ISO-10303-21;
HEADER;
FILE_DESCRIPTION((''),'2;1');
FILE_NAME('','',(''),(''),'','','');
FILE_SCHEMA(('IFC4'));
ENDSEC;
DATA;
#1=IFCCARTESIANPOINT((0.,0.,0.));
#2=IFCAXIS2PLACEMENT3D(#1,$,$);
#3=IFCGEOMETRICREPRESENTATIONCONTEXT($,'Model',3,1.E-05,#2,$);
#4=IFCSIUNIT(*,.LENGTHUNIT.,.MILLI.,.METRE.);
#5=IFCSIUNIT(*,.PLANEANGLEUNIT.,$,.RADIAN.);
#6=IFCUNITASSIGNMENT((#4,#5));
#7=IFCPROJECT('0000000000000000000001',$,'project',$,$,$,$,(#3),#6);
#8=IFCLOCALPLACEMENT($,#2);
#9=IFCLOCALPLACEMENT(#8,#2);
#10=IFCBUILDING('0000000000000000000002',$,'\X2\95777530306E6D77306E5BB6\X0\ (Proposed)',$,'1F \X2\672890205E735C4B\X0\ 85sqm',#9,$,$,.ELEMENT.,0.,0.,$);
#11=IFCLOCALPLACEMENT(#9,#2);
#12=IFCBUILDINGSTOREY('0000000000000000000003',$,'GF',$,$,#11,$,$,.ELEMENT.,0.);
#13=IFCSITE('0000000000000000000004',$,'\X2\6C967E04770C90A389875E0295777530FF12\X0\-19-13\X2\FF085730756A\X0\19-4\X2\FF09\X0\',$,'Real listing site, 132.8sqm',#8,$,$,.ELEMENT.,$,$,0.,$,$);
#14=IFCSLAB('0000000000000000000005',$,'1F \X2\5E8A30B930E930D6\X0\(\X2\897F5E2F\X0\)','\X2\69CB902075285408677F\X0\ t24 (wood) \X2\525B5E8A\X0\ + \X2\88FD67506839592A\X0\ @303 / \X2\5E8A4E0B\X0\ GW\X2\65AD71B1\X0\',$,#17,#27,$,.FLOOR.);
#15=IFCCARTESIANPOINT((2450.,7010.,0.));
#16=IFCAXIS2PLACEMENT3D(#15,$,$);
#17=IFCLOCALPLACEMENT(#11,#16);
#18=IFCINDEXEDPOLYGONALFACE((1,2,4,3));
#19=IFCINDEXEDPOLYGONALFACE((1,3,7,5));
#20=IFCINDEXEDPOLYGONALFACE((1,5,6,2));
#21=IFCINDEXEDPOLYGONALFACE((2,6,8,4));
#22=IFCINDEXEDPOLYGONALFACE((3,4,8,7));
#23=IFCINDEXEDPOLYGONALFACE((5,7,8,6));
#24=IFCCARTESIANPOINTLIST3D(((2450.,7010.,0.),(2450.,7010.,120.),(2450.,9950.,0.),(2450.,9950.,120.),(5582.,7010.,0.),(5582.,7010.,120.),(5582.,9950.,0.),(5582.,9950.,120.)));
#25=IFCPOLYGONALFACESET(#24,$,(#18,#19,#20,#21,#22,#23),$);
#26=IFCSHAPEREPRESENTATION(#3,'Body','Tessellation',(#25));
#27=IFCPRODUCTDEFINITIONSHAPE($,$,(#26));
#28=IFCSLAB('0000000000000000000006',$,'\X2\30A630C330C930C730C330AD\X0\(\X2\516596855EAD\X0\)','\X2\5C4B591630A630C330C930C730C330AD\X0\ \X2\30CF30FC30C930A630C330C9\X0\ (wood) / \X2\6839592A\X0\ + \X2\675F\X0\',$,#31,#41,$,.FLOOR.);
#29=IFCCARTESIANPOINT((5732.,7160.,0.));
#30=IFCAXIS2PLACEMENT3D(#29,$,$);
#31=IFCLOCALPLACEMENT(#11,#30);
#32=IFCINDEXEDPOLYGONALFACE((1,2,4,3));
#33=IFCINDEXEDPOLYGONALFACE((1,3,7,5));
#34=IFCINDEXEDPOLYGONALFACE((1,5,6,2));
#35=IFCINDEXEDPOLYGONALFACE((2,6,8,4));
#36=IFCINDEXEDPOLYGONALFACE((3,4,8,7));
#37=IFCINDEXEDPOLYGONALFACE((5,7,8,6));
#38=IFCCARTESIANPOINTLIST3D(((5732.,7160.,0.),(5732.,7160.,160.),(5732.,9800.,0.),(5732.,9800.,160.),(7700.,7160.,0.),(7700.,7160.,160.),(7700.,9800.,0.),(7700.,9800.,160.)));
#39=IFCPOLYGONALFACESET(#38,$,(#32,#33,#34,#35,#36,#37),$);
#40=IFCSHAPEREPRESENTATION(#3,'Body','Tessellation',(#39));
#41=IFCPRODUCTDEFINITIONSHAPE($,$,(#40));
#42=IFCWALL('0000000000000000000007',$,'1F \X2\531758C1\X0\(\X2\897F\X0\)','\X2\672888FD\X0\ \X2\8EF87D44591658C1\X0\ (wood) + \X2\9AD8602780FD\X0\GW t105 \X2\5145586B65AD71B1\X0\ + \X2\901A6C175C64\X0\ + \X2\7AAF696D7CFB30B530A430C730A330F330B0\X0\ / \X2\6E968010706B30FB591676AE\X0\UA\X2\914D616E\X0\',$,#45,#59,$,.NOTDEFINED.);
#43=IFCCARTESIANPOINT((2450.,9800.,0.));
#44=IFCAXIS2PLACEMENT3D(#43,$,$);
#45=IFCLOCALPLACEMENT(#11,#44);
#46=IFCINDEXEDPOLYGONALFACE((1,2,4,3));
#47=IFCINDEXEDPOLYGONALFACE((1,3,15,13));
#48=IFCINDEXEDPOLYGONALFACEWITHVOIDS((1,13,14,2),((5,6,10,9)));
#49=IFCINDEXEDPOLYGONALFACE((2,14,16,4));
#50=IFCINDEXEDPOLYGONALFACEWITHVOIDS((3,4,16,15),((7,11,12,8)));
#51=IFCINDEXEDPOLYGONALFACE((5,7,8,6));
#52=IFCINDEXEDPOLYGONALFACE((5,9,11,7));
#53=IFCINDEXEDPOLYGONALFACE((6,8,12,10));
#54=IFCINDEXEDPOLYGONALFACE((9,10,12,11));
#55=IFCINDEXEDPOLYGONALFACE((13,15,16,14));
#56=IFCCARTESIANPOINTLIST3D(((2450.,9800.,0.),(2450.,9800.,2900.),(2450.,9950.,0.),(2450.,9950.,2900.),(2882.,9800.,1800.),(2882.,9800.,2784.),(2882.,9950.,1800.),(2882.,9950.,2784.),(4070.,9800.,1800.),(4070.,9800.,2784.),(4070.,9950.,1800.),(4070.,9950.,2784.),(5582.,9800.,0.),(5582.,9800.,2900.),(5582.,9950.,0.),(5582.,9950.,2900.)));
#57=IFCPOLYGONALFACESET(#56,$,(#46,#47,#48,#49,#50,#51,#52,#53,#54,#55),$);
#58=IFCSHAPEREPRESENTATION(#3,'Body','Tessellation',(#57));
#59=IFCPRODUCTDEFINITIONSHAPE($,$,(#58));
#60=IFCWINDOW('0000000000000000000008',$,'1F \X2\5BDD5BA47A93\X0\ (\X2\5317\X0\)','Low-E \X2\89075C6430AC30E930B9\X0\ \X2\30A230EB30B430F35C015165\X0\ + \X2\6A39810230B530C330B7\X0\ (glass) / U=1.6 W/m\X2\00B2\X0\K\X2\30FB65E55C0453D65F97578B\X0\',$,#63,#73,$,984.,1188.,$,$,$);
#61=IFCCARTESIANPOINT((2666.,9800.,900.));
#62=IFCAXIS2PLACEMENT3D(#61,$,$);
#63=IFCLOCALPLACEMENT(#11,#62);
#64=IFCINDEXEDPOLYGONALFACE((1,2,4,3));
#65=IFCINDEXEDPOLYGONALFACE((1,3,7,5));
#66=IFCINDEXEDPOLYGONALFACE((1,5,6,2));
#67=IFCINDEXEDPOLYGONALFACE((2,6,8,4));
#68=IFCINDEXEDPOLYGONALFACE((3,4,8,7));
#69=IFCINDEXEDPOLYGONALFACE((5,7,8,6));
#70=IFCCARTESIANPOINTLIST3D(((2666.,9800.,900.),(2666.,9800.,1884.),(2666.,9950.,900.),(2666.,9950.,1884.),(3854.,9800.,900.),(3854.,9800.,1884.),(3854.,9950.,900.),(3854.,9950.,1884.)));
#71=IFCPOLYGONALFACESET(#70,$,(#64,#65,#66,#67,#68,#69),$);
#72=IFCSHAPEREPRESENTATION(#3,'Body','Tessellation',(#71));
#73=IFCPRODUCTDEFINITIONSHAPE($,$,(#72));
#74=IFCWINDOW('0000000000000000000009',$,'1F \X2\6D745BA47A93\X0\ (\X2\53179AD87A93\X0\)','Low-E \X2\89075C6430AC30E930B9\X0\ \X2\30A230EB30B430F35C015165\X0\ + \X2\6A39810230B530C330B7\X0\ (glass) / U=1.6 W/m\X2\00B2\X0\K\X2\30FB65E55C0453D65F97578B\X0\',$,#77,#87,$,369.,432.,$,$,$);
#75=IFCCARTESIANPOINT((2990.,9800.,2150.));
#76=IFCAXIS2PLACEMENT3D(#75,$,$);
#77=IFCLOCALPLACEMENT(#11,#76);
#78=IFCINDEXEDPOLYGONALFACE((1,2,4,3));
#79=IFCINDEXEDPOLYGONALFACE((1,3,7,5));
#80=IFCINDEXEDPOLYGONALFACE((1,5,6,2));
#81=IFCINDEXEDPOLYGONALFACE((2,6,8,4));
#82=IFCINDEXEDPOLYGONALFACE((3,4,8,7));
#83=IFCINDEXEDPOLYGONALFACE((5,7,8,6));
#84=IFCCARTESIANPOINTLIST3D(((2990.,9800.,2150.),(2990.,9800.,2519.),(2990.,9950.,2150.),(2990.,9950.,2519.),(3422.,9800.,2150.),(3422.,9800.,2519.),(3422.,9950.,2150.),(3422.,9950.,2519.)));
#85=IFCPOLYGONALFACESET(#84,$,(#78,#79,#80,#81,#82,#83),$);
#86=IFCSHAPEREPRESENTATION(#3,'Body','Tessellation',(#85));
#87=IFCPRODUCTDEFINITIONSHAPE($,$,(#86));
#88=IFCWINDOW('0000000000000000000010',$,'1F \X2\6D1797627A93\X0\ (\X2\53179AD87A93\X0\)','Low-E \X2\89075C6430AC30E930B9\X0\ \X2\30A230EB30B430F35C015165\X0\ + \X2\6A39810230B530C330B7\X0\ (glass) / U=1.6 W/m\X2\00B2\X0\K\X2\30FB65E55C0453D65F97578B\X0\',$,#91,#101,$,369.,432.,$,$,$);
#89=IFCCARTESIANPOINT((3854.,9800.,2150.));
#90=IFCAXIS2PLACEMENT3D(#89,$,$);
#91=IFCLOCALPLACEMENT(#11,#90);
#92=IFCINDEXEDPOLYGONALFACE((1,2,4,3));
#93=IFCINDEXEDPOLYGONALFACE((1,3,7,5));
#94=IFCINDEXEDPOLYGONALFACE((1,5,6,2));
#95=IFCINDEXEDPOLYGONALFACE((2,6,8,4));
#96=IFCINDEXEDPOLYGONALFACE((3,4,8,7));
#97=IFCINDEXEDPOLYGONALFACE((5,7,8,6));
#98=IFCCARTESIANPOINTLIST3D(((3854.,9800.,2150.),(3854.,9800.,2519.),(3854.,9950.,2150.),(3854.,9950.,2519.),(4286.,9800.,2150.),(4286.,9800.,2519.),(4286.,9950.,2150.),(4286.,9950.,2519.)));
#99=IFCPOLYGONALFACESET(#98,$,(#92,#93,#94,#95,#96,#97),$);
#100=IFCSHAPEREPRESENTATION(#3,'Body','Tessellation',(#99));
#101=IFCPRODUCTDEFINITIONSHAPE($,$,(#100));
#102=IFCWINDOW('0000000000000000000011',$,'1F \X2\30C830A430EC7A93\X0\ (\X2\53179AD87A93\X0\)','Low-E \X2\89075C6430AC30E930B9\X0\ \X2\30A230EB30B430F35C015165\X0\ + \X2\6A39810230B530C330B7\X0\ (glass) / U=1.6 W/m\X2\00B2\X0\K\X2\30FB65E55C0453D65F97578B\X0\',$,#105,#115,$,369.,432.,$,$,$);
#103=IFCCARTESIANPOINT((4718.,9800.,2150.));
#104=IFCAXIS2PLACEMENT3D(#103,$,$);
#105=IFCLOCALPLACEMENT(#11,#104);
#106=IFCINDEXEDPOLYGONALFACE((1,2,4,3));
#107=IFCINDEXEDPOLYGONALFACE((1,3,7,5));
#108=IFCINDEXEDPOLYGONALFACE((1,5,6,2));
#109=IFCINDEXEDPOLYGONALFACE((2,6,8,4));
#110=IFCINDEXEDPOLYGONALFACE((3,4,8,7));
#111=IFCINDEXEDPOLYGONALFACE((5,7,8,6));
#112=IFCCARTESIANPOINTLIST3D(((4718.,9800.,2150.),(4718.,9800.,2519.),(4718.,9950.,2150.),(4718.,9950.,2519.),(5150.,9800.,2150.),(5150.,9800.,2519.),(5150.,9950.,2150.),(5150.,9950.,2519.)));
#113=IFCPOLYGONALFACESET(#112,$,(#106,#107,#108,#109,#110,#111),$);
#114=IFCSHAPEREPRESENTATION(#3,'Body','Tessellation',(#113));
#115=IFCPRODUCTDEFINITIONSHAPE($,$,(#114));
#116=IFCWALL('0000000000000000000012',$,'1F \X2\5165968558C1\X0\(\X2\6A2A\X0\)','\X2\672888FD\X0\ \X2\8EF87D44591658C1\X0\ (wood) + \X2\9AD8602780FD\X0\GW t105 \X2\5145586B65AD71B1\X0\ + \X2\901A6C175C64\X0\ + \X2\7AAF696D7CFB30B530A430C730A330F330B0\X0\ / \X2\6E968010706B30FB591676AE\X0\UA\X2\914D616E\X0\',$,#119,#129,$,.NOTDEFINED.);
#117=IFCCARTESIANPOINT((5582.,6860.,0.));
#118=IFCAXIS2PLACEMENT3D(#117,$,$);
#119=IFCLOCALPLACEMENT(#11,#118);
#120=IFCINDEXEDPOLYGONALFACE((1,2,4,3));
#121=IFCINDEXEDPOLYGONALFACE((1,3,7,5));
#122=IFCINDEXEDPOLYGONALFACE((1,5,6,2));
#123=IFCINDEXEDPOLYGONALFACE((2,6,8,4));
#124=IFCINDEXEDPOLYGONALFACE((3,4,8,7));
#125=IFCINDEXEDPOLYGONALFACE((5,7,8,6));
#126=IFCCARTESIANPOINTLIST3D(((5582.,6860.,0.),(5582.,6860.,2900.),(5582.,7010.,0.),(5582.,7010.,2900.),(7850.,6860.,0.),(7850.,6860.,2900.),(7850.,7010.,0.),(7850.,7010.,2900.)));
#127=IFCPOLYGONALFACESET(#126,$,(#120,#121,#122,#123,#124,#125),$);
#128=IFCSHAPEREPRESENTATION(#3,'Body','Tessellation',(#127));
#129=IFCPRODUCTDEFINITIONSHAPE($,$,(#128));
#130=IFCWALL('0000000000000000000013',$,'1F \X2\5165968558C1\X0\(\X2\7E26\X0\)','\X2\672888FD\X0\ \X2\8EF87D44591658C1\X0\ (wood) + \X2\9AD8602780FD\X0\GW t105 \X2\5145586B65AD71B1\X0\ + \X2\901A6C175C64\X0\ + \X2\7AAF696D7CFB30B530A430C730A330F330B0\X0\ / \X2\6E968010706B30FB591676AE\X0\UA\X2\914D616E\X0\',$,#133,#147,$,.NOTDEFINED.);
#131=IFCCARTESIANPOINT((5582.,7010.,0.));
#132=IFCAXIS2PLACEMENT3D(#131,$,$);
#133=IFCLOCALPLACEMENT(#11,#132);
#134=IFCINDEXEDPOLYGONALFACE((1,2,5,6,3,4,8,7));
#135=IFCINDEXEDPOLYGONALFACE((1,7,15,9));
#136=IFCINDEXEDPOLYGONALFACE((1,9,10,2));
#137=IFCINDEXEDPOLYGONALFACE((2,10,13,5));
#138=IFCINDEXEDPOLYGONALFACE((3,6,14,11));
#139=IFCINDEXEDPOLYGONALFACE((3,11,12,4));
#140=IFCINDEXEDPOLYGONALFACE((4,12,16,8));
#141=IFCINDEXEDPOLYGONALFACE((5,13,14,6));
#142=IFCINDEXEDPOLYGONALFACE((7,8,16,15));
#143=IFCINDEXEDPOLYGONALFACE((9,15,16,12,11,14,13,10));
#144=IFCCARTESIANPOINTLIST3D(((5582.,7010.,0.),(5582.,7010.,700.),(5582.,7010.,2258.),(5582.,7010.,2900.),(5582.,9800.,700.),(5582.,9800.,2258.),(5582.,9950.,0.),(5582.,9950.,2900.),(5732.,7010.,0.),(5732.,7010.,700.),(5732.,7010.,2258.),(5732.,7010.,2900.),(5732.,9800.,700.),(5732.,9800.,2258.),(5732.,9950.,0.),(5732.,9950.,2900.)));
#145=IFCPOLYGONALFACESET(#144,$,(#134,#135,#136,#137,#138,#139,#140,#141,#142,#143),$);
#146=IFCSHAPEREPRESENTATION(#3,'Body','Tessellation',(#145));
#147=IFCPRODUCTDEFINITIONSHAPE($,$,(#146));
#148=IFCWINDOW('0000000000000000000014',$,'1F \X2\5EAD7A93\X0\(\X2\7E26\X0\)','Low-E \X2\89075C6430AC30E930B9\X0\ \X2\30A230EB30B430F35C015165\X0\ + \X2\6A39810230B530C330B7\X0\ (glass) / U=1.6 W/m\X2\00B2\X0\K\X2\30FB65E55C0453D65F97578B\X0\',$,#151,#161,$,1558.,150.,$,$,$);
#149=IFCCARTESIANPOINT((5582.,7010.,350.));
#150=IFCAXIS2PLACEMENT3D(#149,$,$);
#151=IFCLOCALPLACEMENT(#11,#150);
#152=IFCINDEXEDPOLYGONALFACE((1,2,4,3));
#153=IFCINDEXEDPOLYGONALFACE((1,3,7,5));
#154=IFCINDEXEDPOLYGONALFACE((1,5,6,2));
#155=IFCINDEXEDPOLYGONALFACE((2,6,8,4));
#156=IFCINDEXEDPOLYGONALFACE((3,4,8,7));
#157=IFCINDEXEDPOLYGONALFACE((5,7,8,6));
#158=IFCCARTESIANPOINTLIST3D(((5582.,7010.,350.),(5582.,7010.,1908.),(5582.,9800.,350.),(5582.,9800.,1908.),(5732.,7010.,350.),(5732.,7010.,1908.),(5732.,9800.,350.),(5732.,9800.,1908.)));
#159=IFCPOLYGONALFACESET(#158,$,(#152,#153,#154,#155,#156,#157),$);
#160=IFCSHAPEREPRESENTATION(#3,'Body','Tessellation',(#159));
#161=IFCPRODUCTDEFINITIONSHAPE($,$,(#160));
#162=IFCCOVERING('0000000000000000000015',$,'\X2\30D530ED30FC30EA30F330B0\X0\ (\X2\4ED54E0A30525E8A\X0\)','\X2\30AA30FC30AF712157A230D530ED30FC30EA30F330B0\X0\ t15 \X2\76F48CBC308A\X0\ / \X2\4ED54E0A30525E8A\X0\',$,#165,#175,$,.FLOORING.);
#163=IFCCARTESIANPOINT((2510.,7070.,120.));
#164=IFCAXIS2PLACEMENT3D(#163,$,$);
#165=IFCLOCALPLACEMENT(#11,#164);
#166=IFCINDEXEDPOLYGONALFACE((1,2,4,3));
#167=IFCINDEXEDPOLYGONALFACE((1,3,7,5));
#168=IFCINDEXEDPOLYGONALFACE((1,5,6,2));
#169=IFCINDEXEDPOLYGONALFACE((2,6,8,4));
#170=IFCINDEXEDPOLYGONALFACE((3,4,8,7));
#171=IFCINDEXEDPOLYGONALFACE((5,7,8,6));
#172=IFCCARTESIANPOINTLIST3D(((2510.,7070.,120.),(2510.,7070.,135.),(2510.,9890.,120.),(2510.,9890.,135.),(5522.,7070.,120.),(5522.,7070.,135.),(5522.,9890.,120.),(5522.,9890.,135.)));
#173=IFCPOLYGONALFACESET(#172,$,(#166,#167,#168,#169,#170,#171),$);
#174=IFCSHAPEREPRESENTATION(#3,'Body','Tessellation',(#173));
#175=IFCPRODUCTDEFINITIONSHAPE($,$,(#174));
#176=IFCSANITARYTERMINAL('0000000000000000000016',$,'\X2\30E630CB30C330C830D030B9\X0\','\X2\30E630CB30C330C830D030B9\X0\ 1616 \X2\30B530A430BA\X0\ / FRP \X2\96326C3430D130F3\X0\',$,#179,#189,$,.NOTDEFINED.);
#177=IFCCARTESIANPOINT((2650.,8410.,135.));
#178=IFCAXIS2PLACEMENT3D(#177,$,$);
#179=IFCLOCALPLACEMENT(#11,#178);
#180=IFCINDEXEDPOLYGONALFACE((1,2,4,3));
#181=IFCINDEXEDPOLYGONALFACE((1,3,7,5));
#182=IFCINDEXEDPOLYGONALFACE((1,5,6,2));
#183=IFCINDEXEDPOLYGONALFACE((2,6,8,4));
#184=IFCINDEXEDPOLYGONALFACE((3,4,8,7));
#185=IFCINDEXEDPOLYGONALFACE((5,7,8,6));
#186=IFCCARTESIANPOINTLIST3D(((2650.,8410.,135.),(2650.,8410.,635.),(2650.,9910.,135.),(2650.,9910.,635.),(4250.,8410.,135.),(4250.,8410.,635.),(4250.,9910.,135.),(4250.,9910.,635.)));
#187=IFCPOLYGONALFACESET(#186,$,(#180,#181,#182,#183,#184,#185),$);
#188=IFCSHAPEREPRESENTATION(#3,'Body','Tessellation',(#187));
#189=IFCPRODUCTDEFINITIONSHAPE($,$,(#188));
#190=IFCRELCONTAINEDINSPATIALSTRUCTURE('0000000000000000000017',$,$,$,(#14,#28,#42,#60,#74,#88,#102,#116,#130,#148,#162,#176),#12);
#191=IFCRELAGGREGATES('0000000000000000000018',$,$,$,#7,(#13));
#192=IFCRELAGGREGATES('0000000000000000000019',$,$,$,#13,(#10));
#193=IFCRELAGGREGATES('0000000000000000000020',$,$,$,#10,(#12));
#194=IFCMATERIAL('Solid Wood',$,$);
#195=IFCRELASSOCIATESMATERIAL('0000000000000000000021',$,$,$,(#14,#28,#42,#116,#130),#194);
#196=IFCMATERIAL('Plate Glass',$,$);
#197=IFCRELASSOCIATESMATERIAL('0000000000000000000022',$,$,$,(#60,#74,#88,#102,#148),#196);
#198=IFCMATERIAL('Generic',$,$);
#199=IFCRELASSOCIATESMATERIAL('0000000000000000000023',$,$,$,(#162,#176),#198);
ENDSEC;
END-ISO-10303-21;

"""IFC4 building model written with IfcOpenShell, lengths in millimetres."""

from ifc_helpers import new_model, si_unit, frame, frame_2d, origin, place, context, project, spatial, rectangle, extrude, material, element, fill, save


model = new_model("IFC4")

# Units and contexts
model_context = context("Model", 3, precision=1e-05, world=origin())
ifc_project = project(units=[si_unit("LENGTHUNIT", "METRE", prefix="MILLI"), si_unit("PLANEANGLEUNIT", "RADIAN")], contexts=[model_context])

# Site, building, storey
site_placement = place(None, origin())
site = spatial("IfcSite", under=ifc_project, at=site_placement, Name="沖縄県那覇市長田２-19-13（地番19-4）", ObjectType="Real listing site, 132.8sqm", CompositionType="ELEMENT", RefElevation=0.0)
building_placement = place(site_placement, origin())
building = spatial("IfcBuilding", under=site, at=building_placement, Name="長田の海の家 (Proposed)", ObjectType="1F 木造平屋 85sqm", CompositionType="ELEMENT", ElevationOfRefHeight=0.0, ElevationOfTerrain=0.0)
storey_placement = place(building_placement, origin())
storey = spatial("IfcBuildingStorey", under=building, at=storey_placement, Name="GF", CompositionType="ELEMENT", Elevation=0.0)

# Slabs
ifc_material_1 = material(Name="Solid Wood")
slab_1_placement = place(storey_placement, frame((2450.0, 7010.0, 0.0)))
element("IfcSlab", 1, at=slab_1_placement, inside=storey, material=ifc_material_1, Name="1F 床スラブ(西帯)", Description="構造用合板 t24 (wood) 剛床 + 製材根太 @303 / 床下 GW断熱", PredefinedType="FLOOR", context=model_context, shape_type="SweptSolid", body=[
    extrude(rectangle(XDim=3132.0, YDim=2940.0, at=frame_2d((1566.0, 1470.0))), frame((2450.0, 7010.0, 0.0)), (0.0, 0.0, 1.0), 120.0),
])
slab_2_placement = place(storey_placement, frame((5732.0, 7160.0, 0.0)))
element("IfcSlab", 2, at=slab_2_placement, inside=storey, material=ifc_material_1, Name="ウッドデッキ(入隅庭)", Description="屋外ウッドデッキ ハードウッド (wood) / 根太 + 束", PredefinedType="FLOOR", context=model_context, shape_type="SweptSolid", body=[
    extrude(rectangle(XDim=1968.0, YDim=2640.0, at=frame_2d((984.0, 1320.0))), frame((5732.0, 7160.0, 0.0)), (0.0, 0.0, 1.0), 160.0),
])

# Wall, openings, windows
wall_1_placement = place(storey_placement, frame((2450.0, 9800.0, 0.0)))
wall_1 = element("IfcWall", 3, at=wall_1_placement, inside=storey, material=ifc_material_1, Name="1F 北壁(西)", Description="木製 軸組外壁 (wood) + 高性能GW t105 充填断熱 + 通気層 + 窯業系サイディング / 準耐火・外皮UA配慮", PredefinedType="NOTDEFINED", context=model_context, shape_type="SweptSolid", body=[
    extrude(rectangle(XDim=3132.0, YDim=150.0, at=frame_2d((1566.0, 75.0))), frame((2450.0, 9800.0, 0.0)), (0.0, 0.0, 1.0), 2900.0),
])
opening_1_placement = place(storey_placement, frame((2666.0, 9800.0, 900.0)))
opening_1 = element("IfcOpeningElement", 4, at=opening_1_placement, cuts=wall_1, PredefinedType="NOTDEFINED", context=model_context, shape_type="SweptSolid", body=[
    extrude(rectangle(XDim=1188.0, YDim=150.0, at=frame_2d((594.0, 75.0))), frame((2666.0, 9800.0, 900.0)), (0.0, 0.0, 1.0), 984.0),
])
opening_2_placement = place(storey_placement, frame((2990.0, 9800.0, 2150.0)))
opening_2 = element("IfcOpeningElement", 5, at=opening_2_placement, cuts=wall_1, PredefinedType="NOTDEFINED", context=model_context, shape_type="SweptSolid", body=[
    extrude(rectangle(XDim=432.0, YDim=150.0, at=frame_2d((216.0, 75.0))), frame((2990.0, 9800.0, 2150.0)), (0.0, 0.0, 1.0), 369.0),
])
opening_3_placement = place(storey_placement, frame((3854.0, 9800.0, 2150.0)))
opening_3 = element("IfcOpeningElement", 6, at=opening_3_placement, cuts=wall_1, PredefinedType="NOTDEFINED", context=model_context, shape_type="SweptSolid", body=[
    extrude(rectangle(XDim=432.0, YDim=150.0, at=frame_2d((216.0, 75.0))), frame((3854.0, 9800.0, 2150.0)), (0.0, 0.0, 1.0), 369.0),
])
opening_4_placement = place(storey_placement, frame((4718.0, 9800.0, 2150.0)))
opening_4 = element("IfcOpeningElement", 7, at=opening_4_placement, cuts=wall_1, PredefinedType="NOTDEFINED", context=model_context, shape_type="SweptSolid", body=[
    extrude(rectangle(XDim=432.0, YDim=150.0, at=frame_2d((216.0, 75.0))), frame((4718.0, 9800.0, 2150.0)), (0.0, 0.0, 1.0), 369.0),
])
ifc_material_2 = material(Name="Plate Glass")
window_1_placement = place(storey_placement, frame((2666.0, 9800.0, 900.0)))
window_1 = element("IfcWindow", 8, at=window_1_placement, inside=storey, material=ifc_material_2, Name="1F 寝室窓 (北)", Description="Low-E 複層ガラス アルゴン封入 + 樹脂サッシ (glass) / U=1.6 W/m²K・日射取得型", OverallHeight=984.0, OverallWidth=1188.0, context=model_context, shape_type="SweptSolid", body=[
    extrude(rectangle(XDim=1188.0, YDim=150.0, at=frame_2d((594.0, 75.0))), frame((2666.0, 9800.0, 900.0)), (0.0, 0.0, 1.0), 984.0),
])
fill(opening_1, window_1)
window_2_placement = place(storey_placement, frame((2990.0, 9800.0, 2150.0)))
window_2 = element("IfcWindow", 9, at=window_2_placement, inside=storey, material=ifc_material_2, Name="1F 浴室窓 (北高窓)", Description="Low-E 複層ガラス アルゴン封入 + 樹脂サッシ (glass) / U=1.6 W/m²K・日射取得型", OverallHeight=369.0, OverallWidth=432.0, context=model_context, shape_type="SweptSolid", body=[
    extrude(rectangle(XDim=432.0, YDim=150.0, at=frame_2d((216.0, 75.0))), frame((2990.0, 9800.0, 2150.0)), (0.0, 0.0, 1.0), 369.0),
])
fill(opening_2, window_2)
window_3_placement = place(storey_placement, frame((3854.0, 9800.0, 2150.0)))
window_3 = element("IfcWindow", 10, at=window_3_placement, inside=storey, material=ifc_material_2, Name="1F 洗面窓 (北高窓)", Description="Low-E 複層ガラス アルゴン封入 + 樹脂サッシ (glass) / U=1.6 W/m²K・日射取得型", OverallHeight=369.0, OverallWidth=432.0, context=model_context, shape_type="SweptSolid", body=[
    extrude(rectangle(XDim=432.0, YDim=150.0, at=frame_2d((216.0, 75.0))), frame((3854.0, 9800.0, 2150.0)), (0.0, 0.0, 1.0), 369.0),
])
fill(opening_3, window_3)
window_4_placement = place(storey_placement, frame((4718.0, 9800.0, 2150.0)))
window_4 = element("IfcWindow", 11, at=window_4_placement, inside=storey, material=ifc_material_2, Name="1F トイレ窓 (北高窓)", Description="Low-E 複層ガラス アルゴン封入 + 樹脂サッシ (glass) / U=1.6 W/m²K・日射取得型", OverallHeight=369.0, OverallWidth=432.0, context=model_context, shape_type="SweptSolid", body=[
    extrude(rectangle(XDim=432.0, YDim=150.0, at=frame_2d((216.0, 75.0))), frame((4718.0, 9800.0, 2150.0)), (0.0, 0.0, 1.0), 369.0),
])
fill(opening_4, window_4)

# Wall
wall_2_placement = place(storey_placement, frame((5582.0, 6860.0, 0.0)))
element("IfcWall", 12, at=wall_2_placement, inside=storey, material=ifc_material_1, Name="1F 入隅壁(横)", Description="木製 軸組外壁 (wood) + 高性能GW t105 充填断熱 + 通気層 + 窯業系サイディング / 準耐火・外皮UA配慮", PredefinedType="NOTDEFINED", context=model_context, shape_type="SweptSolid", body=[
    extrude(rectangle(XDim=2268.0, YDim=150.0, at=frame_2d((1134.0, 75.0))), frame((5582.0, 6860.0, 0.0)), (0.0, 0.0, 1.0), 2900.0),
])

# Wall, opening, window
wall_3_placement = place(storey_placement, frame((5582.0, 7010.0, 0.0)))
wall_3 = element("IfcWall", 13, at=wall_3_placement, inside=storey, material=ifc_material_1, Name="1F 入隅壁(縦)", Description="木製 軸組外壁 (wood) + 高性能GW t105 充填断熱 + 通気層 + 窯業系サイディング / 準耐火・外皮UA配慮", PredefinedType="NOTDEFINED", context=model_context, shape_type="SweptSolid", body=[
    extrude(rectangle(XDim=150.0, YDim=2940.0, at=frame_2d((75.0, 1470.0))), frame((5582.0, 7010.0, 0.0)), (0.0, 0.0, 1.0), 2900.0),
])
opening_5_placement = place(storey_placement, frame((5582.0, 7010.0, 350.0)))
opening_5 = element("IfcOpeningElement", 14, at=opening_5_placement, cuts=wall_3, PredefinedType="NOTDEFINED", context=model_context, shape_type="SweptSolid", body=[
    extrude(rectangle(XDim=150.0, YDim=2790.0, at=frame_2d((75.0, 1395.0))), frame((5582.0, 7010.0, 350.0)), (0.0, 0.0, 1.0), 1558.0),
])
window_5_placement = place(storey_placement, frame((5582.0, 7010.0, 350.0)))
window_5 = element("IfcWindow", 15, at=window_5_placement, inside=storey, material=ifc_material_2, Name="1F 庭窓(縦)", Description="Low-E 複層ガラス アルゴン封入 + 樹脂サッシ (glass) / U=1.6 W/m²K・日射取得型", OverallHeight=1558.0, OverallWidth=150.0, context=model_context, shape_type="SweptSolid", body=[
    extrude(rectangle(XDim=150.0, YDim=2790.0, at=frame_2d((75.0, 1395.0))), frame((5582.0, 7010.0, 350.0)), (0.0, 0.0, 1.0), 1558.0),
])
fill(opening_5, window_5)

# Covering
ifc_material_3 = material(Name="Generic")
covering_placement = place(storey_placement, frame((2510.0, 7070.0, 120.0)))
element("IfcCovering", 16, at=covering_placement, inside=storey, material=ifc_material_3, Name="フローリング (仕上げ床)", Description="オーク無垢フローリング t15 直貼り / 仕上げ床", PredefinedType="FLOORING", context=model_context, shape_type="SweptSolid", body=[
    extrude(rectangle(XDim=3012.0, YDim=2820.0, at=frame_2d((1506.0, 1410.0))), frame((2510.0, 7070.0, 120.0)), (0.0, 0.0, 1.0), 15.0),
])

# Sanitary terminal
sanitary_terminal_1_placement = place(storey_placement, frame((2650.0, 8410.0, 135.0)))
element("IfcSanitaryTerminal", 17, at=sanitary_terminal_1_placement, inside=storey, material=ifc_material_3, Name="ユニットバス", Description="ユニットバス 1616 サイズ / FRP 防水パン", PredefinedType="NOTDEFINED", context=model_context, shape_type="SweptSolid", body=[
    extrude(rectangle(XDim=1600.0, YDim=1500.0, at=frame_2d((800.0, 750.0))), frame((2650.0, 8410.0, 135.0)), (0.0, 0.0, 1.0), 500.0),
])

save(model, "model.ifc")
